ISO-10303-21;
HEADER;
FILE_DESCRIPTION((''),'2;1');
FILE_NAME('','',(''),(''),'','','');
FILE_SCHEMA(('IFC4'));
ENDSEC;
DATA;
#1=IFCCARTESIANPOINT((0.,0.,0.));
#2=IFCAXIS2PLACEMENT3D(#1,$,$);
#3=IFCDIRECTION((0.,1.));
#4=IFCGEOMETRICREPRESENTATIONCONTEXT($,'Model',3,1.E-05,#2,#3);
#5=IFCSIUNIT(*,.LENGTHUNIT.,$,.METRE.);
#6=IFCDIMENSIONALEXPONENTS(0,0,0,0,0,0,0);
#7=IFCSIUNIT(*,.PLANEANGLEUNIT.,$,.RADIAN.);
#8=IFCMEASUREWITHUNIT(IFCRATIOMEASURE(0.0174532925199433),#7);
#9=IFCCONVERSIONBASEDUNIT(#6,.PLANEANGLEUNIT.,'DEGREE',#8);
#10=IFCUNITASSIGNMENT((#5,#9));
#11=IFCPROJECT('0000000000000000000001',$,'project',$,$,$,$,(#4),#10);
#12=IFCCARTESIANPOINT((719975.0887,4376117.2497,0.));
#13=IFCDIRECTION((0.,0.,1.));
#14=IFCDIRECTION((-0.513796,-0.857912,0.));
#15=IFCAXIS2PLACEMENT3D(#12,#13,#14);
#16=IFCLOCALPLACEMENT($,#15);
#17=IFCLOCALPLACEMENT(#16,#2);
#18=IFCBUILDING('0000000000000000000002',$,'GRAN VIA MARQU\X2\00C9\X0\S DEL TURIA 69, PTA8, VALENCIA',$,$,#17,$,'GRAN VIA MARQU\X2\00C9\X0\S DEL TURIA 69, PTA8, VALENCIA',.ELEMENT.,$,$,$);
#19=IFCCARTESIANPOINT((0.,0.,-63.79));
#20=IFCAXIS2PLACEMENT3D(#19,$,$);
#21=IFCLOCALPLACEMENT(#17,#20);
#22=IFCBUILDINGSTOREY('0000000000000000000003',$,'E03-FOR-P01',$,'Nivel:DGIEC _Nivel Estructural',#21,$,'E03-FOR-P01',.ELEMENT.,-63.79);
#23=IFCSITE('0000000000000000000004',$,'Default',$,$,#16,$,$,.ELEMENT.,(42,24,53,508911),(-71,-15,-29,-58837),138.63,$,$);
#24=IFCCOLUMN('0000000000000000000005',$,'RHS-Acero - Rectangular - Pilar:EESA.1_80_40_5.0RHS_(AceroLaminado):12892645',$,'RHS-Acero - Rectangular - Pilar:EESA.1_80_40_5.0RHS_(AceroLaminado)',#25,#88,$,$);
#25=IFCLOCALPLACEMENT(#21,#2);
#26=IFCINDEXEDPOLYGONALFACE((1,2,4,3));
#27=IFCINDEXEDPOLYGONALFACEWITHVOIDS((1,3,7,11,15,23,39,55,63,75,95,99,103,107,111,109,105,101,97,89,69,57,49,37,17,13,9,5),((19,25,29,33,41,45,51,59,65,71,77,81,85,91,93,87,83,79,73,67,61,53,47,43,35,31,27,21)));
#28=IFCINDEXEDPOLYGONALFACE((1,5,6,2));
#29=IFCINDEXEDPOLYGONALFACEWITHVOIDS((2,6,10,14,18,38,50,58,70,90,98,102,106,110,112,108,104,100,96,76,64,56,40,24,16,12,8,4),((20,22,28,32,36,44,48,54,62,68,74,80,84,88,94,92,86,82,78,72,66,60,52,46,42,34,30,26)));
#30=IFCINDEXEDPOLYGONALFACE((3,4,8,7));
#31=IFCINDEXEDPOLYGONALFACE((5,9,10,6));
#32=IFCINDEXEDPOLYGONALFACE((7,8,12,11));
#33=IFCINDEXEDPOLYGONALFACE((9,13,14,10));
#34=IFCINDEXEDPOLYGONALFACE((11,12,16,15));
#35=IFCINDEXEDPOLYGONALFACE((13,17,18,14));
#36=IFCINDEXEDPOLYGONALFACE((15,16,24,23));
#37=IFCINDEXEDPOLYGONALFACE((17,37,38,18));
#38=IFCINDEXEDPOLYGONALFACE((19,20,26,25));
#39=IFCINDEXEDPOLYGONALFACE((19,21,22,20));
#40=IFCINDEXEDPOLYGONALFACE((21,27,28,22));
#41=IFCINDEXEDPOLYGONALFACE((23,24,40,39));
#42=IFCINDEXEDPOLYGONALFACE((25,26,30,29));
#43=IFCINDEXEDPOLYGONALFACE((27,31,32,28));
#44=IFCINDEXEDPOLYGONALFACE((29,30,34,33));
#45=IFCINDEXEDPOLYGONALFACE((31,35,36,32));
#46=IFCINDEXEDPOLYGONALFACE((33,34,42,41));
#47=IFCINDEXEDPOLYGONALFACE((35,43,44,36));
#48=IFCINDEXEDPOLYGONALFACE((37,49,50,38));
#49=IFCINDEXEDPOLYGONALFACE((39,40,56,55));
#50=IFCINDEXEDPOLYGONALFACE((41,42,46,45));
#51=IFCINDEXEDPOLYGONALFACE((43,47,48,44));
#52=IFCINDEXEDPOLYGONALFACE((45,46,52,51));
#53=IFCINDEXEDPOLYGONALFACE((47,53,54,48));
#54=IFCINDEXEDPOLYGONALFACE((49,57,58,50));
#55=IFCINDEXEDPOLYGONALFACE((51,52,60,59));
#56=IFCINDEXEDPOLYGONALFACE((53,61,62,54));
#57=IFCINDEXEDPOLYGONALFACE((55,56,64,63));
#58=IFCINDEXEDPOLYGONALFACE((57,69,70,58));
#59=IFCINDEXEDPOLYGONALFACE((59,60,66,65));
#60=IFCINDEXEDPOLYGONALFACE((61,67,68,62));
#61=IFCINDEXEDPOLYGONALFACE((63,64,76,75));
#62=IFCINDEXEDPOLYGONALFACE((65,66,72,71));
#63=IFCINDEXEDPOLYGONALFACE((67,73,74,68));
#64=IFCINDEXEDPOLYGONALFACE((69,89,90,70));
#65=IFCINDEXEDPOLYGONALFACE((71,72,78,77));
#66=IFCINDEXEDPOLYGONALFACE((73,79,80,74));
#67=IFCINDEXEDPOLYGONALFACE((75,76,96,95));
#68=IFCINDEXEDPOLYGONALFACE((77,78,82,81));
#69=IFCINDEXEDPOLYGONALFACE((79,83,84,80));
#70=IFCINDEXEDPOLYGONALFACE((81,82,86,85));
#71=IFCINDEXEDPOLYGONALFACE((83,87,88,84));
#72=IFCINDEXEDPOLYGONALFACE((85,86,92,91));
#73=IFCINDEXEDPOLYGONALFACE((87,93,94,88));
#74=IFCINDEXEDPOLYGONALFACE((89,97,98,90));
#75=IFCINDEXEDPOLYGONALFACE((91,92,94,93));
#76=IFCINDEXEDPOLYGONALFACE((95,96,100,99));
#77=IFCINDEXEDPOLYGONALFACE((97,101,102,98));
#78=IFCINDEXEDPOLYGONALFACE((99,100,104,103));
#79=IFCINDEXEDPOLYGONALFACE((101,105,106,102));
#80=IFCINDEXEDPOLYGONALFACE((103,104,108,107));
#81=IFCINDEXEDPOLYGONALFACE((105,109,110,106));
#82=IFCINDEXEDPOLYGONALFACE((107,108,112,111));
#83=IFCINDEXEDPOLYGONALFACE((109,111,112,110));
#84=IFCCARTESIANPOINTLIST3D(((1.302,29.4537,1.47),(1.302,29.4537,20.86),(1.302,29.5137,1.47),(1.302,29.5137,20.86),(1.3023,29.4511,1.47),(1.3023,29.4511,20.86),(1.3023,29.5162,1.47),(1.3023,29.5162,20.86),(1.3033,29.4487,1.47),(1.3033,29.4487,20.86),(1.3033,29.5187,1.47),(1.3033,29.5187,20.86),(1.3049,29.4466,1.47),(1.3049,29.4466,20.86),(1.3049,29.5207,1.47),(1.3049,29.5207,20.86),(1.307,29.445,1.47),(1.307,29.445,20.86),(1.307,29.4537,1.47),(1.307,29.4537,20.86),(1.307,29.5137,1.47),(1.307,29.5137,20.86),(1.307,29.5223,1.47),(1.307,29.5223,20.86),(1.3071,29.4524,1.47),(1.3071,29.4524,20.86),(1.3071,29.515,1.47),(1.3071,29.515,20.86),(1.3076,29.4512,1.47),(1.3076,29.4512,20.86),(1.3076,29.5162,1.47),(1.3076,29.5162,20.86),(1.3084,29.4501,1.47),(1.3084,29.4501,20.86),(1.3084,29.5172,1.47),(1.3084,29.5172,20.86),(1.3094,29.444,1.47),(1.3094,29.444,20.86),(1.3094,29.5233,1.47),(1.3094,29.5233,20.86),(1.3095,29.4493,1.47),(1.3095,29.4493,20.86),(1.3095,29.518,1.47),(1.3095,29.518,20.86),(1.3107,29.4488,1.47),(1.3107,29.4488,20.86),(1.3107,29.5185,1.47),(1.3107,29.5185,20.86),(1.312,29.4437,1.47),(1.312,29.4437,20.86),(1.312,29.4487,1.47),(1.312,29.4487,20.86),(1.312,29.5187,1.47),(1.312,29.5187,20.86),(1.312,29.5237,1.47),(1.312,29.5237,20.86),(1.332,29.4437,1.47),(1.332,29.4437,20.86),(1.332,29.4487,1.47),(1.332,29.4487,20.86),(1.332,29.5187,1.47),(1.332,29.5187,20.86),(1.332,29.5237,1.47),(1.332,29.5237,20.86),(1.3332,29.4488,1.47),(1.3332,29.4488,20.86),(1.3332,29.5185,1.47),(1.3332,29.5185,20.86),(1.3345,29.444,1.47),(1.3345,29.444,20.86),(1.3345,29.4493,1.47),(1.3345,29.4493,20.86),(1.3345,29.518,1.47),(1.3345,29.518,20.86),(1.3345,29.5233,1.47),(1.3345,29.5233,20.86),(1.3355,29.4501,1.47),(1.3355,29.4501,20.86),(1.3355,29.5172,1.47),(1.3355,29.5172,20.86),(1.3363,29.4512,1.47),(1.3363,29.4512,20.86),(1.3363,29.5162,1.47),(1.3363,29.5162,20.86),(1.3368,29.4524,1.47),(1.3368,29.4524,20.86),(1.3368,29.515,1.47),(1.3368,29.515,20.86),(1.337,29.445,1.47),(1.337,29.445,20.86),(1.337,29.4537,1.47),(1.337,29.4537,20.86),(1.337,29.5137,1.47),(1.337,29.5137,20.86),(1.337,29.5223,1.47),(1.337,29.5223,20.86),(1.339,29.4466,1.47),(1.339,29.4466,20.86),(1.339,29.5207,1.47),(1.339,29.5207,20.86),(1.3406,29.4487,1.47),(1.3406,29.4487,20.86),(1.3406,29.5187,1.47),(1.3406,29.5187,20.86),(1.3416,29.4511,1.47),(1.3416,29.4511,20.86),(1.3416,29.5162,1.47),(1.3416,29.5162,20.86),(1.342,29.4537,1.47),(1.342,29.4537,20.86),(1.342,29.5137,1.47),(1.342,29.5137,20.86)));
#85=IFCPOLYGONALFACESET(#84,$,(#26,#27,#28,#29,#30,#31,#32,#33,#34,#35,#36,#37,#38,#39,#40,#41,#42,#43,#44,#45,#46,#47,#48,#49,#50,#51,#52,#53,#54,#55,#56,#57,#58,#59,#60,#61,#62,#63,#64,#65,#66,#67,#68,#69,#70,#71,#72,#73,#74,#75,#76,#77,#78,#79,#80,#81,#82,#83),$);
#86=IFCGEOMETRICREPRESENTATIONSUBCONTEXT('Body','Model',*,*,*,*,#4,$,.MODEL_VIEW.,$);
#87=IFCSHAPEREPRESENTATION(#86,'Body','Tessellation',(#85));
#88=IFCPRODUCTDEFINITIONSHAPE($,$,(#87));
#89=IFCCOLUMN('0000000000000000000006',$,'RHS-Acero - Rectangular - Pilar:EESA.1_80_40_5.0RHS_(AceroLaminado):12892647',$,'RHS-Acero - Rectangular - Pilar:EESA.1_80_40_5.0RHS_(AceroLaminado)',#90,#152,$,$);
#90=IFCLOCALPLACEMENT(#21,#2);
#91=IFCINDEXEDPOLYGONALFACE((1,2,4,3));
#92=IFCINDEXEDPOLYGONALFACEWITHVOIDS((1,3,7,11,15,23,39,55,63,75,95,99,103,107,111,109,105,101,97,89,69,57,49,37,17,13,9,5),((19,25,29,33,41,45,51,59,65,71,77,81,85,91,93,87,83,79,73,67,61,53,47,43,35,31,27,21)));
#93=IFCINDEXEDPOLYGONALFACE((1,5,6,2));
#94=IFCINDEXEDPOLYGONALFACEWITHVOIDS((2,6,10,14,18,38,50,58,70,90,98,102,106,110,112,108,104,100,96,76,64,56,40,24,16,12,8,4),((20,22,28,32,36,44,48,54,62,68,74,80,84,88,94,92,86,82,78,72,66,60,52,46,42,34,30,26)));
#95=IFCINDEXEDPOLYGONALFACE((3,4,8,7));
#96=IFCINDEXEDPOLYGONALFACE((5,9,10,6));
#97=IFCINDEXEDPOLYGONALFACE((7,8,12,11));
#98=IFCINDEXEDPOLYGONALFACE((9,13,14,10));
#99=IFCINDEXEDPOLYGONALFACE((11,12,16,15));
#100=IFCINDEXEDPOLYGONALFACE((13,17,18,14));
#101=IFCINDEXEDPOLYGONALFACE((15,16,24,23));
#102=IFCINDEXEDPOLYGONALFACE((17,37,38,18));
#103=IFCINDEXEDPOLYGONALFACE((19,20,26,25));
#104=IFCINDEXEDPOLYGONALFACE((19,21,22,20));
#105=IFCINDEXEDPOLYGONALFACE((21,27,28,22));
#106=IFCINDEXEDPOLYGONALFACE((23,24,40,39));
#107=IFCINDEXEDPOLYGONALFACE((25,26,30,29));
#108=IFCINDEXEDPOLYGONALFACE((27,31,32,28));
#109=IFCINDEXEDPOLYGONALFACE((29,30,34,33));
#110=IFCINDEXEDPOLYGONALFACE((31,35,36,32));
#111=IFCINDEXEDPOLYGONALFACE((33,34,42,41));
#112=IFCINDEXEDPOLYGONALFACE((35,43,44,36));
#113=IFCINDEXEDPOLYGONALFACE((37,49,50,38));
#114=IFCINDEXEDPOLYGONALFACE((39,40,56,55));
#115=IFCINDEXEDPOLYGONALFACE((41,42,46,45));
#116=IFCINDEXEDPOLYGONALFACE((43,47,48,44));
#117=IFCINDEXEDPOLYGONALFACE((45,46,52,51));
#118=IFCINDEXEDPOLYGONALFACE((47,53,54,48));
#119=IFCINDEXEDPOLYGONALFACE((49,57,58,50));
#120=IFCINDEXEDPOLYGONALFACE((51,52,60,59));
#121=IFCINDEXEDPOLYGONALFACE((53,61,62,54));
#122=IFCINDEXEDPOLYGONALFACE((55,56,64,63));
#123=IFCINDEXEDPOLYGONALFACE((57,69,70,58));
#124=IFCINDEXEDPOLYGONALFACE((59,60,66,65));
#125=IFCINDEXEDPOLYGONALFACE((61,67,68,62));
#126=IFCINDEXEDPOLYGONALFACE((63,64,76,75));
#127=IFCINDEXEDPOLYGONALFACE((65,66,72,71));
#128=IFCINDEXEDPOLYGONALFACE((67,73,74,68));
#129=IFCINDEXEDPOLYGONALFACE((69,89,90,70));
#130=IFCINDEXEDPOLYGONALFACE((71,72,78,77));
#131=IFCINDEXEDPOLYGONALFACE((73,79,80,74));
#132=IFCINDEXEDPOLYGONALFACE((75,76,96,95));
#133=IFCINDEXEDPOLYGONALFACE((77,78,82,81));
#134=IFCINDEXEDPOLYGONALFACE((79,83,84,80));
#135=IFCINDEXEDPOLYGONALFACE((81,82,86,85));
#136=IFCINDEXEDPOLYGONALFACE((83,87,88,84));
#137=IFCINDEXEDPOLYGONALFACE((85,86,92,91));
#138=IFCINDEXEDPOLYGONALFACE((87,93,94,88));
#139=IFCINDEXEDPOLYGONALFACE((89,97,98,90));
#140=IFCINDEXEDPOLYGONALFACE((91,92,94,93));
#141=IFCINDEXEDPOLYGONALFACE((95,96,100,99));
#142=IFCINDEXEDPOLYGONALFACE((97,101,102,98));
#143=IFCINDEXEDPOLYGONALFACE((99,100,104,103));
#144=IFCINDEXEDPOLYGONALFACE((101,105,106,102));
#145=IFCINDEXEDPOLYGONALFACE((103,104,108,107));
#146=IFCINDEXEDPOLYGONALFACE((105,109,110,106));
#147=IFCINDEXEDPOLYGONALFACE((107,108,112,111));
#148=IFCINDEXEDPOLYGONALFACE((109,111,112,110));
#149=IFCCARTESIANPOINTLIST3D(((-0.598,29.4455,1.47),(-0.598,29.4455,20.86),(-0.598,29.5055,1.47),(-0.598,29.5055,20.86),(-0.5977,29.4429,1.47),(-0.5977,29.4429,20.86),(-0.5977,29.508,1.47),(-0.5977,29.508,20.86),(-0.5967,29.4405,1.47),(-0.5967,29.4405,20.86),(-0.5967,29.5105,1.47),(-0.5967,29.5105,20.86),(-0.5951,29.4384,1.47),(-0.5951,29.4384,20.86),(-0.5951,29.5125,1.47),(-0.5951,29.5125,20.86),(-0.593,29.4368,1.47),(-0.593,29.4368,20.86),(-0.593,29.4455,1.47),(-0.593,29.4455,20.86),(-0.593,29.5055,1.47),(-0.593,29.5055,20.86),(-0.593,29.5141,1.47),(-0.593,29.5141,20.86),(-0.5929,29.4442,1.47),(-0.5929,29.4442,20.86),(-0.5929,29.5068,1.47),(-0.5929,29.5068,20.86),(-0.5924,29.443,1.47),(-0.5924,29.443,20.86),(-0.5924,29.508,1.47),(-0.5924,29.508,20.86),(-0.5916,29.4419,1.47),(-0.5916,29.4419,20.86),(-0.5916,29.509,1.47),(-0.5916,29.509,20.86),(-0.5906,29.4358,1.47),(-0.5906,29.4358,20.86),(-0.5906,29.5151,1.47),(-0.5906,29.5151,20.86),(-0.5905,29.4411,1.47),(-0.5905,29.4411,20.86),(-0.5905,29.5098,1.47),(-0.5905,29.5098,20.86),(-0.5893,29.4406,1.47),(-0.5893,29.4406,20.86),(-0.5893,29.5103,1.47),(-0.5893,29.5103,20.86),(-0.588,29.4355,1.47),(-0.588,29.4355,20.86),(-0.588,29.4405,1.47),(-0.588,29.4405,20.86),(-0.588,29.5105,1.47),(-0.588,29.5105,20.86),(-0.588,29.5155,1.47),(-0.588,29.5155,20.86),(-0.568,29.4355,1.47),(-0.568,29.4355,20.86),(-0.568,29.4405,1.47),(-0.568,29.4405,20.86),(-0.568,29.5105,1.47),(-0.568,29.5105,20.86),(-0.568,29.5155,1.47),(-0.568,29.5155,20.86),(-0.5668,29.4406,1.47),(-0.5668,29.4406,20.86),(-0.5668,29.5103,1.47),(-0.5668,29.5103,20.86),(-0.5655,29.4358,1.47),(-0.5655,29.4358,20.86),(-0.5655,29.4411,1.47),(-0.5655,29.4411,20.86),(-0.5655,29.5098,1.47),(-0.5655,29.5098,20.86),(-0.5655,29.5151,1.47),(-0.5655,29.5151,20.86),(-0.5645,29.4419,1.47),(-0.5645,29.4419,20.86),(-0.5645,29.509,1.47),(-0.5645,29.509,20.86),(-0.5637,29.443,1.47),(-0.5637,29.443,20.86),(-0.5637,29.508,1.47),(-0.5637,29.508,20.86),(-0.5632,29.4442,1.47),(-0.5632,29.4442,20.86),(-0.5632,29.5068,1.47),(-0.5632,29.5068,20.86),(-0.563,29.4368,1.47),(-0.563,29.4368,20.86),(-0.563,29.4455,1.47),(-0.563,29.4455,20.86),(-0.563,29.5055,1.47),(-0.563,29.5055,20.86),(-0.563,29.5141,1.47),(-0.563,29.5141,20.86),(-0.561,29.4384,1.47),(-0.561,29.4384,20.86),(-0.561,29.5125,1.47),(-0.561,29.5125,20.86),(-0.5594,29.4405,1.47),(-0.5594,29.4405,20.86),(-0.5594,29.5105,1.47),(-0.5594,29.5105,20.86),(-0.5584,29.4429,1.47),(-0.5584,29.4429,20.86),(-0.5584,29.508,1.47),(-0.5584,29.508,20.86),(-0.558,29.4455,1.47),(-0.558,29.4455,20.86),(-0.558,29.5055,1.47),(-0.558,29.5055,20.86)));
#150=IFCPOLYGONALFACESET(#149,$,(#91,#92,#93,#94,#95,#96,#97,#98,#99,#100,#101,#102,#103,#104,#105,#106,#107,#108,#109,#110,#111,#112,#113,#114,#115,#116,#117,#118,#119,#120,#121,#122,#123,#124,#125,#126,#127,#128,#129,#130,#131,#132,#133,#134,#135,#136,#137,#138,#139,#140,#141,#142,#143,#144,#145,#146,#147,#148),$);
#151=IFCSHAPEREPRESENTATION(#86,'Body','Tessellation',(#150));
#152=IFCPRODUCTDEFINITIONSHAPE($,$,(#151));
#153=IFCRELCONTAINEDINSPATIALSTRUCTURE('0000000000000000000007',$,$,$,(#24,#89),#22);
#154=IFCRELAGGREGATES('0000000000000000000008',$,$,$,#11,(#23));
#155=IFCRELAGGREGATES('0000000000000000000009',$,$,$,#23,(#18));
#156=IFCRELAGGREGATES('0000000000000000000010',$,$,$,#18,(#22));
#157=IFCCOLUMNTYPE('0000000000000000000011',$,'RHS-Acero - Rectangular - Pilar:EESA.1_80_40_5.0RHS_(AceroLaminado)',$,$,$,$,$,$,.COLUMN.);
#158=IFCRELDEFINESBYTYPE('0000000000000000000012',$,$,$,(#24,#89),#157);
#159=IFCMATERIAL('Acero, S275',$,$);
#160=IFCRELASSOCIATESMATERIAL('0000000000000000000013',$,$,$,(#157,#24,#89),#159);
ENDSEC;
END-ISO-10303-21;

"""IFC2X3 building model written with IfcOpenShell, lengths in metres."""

from ifc_helpers import new_model, entity, si_unit, converted_unit, direction, frame, frame_2d, origin, place, context, subcontext, project, spatial, polyline, circle_curve, parameter, trimmed, segment, composite_curve, outline, extrude, source, transform, mapped, material, type_object, type_shapes, element, save


model = new_model("IFC2X3")

# Units and contexts
model_context = context("Model", 3, precision=1e-05, world=origin(), true_north=direction((0.0, 1.0)))
body_context = subcontext(model_context, "Body", "Model", "MODEL_VIEW")
ifc_project = project(units=[si_unit("LENGTHUNIT", "METRE"), converted_unit("PLANEANGLEUNIT", "DEGREE", entity("IfcRatioMeasure", 0.0174532925199433), si_unit("PLANEANGLEUNIT", "RADIAN"), dimensions=[0, 0, 0, 0, 0, 0, 0])], contexts=[model_context])

# Site, building, storey
site_placement = place(None, frame((719975.0887, 4376117.2497, 0.0), z_axis=(0.0, 0.0, 1.0), x_axis=(-0.513796, -0.857912, 0.0)))
site = spatial("IfcSite", under=ifc_project, at=site_placement, Name="Default", CompositionType="ELEMENT", RefLatitude=(42, 24, 53, 508911), RefLongitude=(-71, -15, -29, -58837), RefElevation=138.63)
building_placement = place(site_placement, origin())
building = spatial("IfcBuilding", under=site, at=building_placement, Name="GRAN VIA MARQUÉS DEL TURIA 69, PTA8, VALENCIA", LongName="GRAN VIA MARQUÉS DEL TURIA 69, PTA8, VALENCIA", CompositionType="ELEMENT")
storey_placement = place(building_placement, frame((0.0, 0.0, -63.79)))
storey = spatial("IfcBuildingStorey", under=building, at=storey_placement, Name="E03-FOR-P01", ObjectType="Nivel:DGIEC _Nivel Estructural", LongName="E03-FOR-P01", CompositionType="ELEMENT", Elevation=-63.79)

# Columns
ifc_material_1 = material(Name="Acero, S275")
column_type_1 = type_object("IfcColumnType", Name="RHS-Acero - Rectangular - Pilar:EESA.1_80_40_5.0RHS_(AceroLaminado)", PredefinedType="COLUMN", material=ifc_material_1)
shared_shape_1 = source(origin(), body_context, "Body", "SweptSolid", [
    extrude(outline(composite_curve([segment(polyline([(-0.01, -0.04), (0.01, -0.04)]), True, "CONTINUOUS"), segment(trimmed(circle_curve(frame_2d((0.01, -0.03), x_axis=(-1.0, 0.0)), 0.01), [parameter(90.0)], [parameter(180.0)], True, "PARAMETER"), True, "CONTINUOUS"), segment(polyline([(0.02, -0.03), (0.02, 0.03)]), True, "CONTINUOUS"), segment(trimmed(circle_curve(frame_2d((0.01, 0.03), x_axis=(-1.0, 0.0)), 0.01), [parameter(180.0)], [parameter(270.0)], True, "PARAMETER"), True, "CONTINUOUS"), segment(polyline([(0.01, 0.04), (-0.01, 0.04)]), True, "CONTINUOUS"), segment(trimmed(circle_curve(frame_2d((-0.01, 0.03), x_axis=(-1.0, 0.0)), 0.01), [parameter(270.0)], [parameter(360.0)], True, "PARAMETER"), True, "CONTINUOUS"), segment(polyline([(-0.02, 0.03), (-0.02, -0.03)]), True, "CONTINUOUS"), segment(trimmed(circle_curve(frame_2d((-0.01, -0.03), x_axis=(-1.0, 0.0)), 0.01), [parameter(360.0)], [parameter(90.0)], True, "PARAMETER"), True, "CONTINUOUS")], self_intersect=False), holes=[composite_curve([segment(trimmed(circle_curve(frame_2d((-0.01, -0.03), x_axis=(-1.0, 0.0)), 0.005), [parameter(0.0)], [parameter(90.0)], True, "PARAMETER"), False, "CONTINUOUS"), segment(polyline([(-0.015, -0.03), (-0.015, 0.03)]), True, "CONTINUOUS"), segment(trimmed(circle_curve(frame_2d((-0.01, 0.03), x_axis=(-1.0, 0.0)), 0.005), [parameter(270.0)], [parameter(0.0)], True, "PARAMETER"), False, "CONTINUOUS"), segment(polyline([(-0.01, 0.035), (0.01, 0.035)]), True, "CONTINUOUS"), segment(trimmed(circle_curve(frame_2d((0.01, 0.03), x_axis=(-1.0, 0.0)), 0.005), [parameter(180.0)], [parameter(270.0)], True, "PARAMETER"), False, "CONTINUOUS"), segment(polyline([(0.015, 0.03), (0.015, -0.03)]), True, "CONTINUOUS"), segment(trimmed(circle_curve(frame_2d((0.01, -0.03), x_axis=(-1.0, 0.0)), 0.005), [parameter(90.0)], [parameter(180.0)], True, "PARAMETER"), False, "CONTINUOUS"), segment(polyline([(0.01, -0.035), (-0.01, -0.035)]), True, "CONTINUOUS")], self_intersect=False)]), frame((0.0, 0.0, -62.32), z_axis=(0.0, 0.0, 1.0), x_axis=(-1.0, 0.0, 0.0)), (0.0, 0.0, 1.0), 19.39),
])
type_shapes(column_type_1, [shared_shape_1])
for number, where, z_axis, x_axis, name in (
    (1, (1.322, 29.4837, 63.79), (0.0, 0.0, 1.0), (-1.0, 0.0, 0.0), "RHS-Acero - Rectangular - Pilar:EESA.1_80_40_5.0RHS_(AceroLaminado):12892645"),
    (2, (-0.578, 29.4755, 63.79), (0.0, 0.0, 1.0), (-1.0, 0.0, 0.0), "RHS-Acero - Rectangular - Pilar:EESA.1_80_40_5.0RHS_(AceroLaminado):12892647"),
):
    element("IfcColumn", number, at=place(storey_placement, frame(where, z_axis=z_axis, x_axis=x_axis)), inside=storey, type_object=column_type_1, material=ifc_material_1, Name=name, ObjectType="RHS-Acero - Rectangular - Pilar:EESA.1_80_40_5.0RHS_(AceroLaminado)", context=body_context, shape_type="MappedRepresentation", body=[
        mapped(shared_shape_1, transform((0.0, 0.0, 0.0), scale=1.0)),
    ])

save(model, "model.ifc")
